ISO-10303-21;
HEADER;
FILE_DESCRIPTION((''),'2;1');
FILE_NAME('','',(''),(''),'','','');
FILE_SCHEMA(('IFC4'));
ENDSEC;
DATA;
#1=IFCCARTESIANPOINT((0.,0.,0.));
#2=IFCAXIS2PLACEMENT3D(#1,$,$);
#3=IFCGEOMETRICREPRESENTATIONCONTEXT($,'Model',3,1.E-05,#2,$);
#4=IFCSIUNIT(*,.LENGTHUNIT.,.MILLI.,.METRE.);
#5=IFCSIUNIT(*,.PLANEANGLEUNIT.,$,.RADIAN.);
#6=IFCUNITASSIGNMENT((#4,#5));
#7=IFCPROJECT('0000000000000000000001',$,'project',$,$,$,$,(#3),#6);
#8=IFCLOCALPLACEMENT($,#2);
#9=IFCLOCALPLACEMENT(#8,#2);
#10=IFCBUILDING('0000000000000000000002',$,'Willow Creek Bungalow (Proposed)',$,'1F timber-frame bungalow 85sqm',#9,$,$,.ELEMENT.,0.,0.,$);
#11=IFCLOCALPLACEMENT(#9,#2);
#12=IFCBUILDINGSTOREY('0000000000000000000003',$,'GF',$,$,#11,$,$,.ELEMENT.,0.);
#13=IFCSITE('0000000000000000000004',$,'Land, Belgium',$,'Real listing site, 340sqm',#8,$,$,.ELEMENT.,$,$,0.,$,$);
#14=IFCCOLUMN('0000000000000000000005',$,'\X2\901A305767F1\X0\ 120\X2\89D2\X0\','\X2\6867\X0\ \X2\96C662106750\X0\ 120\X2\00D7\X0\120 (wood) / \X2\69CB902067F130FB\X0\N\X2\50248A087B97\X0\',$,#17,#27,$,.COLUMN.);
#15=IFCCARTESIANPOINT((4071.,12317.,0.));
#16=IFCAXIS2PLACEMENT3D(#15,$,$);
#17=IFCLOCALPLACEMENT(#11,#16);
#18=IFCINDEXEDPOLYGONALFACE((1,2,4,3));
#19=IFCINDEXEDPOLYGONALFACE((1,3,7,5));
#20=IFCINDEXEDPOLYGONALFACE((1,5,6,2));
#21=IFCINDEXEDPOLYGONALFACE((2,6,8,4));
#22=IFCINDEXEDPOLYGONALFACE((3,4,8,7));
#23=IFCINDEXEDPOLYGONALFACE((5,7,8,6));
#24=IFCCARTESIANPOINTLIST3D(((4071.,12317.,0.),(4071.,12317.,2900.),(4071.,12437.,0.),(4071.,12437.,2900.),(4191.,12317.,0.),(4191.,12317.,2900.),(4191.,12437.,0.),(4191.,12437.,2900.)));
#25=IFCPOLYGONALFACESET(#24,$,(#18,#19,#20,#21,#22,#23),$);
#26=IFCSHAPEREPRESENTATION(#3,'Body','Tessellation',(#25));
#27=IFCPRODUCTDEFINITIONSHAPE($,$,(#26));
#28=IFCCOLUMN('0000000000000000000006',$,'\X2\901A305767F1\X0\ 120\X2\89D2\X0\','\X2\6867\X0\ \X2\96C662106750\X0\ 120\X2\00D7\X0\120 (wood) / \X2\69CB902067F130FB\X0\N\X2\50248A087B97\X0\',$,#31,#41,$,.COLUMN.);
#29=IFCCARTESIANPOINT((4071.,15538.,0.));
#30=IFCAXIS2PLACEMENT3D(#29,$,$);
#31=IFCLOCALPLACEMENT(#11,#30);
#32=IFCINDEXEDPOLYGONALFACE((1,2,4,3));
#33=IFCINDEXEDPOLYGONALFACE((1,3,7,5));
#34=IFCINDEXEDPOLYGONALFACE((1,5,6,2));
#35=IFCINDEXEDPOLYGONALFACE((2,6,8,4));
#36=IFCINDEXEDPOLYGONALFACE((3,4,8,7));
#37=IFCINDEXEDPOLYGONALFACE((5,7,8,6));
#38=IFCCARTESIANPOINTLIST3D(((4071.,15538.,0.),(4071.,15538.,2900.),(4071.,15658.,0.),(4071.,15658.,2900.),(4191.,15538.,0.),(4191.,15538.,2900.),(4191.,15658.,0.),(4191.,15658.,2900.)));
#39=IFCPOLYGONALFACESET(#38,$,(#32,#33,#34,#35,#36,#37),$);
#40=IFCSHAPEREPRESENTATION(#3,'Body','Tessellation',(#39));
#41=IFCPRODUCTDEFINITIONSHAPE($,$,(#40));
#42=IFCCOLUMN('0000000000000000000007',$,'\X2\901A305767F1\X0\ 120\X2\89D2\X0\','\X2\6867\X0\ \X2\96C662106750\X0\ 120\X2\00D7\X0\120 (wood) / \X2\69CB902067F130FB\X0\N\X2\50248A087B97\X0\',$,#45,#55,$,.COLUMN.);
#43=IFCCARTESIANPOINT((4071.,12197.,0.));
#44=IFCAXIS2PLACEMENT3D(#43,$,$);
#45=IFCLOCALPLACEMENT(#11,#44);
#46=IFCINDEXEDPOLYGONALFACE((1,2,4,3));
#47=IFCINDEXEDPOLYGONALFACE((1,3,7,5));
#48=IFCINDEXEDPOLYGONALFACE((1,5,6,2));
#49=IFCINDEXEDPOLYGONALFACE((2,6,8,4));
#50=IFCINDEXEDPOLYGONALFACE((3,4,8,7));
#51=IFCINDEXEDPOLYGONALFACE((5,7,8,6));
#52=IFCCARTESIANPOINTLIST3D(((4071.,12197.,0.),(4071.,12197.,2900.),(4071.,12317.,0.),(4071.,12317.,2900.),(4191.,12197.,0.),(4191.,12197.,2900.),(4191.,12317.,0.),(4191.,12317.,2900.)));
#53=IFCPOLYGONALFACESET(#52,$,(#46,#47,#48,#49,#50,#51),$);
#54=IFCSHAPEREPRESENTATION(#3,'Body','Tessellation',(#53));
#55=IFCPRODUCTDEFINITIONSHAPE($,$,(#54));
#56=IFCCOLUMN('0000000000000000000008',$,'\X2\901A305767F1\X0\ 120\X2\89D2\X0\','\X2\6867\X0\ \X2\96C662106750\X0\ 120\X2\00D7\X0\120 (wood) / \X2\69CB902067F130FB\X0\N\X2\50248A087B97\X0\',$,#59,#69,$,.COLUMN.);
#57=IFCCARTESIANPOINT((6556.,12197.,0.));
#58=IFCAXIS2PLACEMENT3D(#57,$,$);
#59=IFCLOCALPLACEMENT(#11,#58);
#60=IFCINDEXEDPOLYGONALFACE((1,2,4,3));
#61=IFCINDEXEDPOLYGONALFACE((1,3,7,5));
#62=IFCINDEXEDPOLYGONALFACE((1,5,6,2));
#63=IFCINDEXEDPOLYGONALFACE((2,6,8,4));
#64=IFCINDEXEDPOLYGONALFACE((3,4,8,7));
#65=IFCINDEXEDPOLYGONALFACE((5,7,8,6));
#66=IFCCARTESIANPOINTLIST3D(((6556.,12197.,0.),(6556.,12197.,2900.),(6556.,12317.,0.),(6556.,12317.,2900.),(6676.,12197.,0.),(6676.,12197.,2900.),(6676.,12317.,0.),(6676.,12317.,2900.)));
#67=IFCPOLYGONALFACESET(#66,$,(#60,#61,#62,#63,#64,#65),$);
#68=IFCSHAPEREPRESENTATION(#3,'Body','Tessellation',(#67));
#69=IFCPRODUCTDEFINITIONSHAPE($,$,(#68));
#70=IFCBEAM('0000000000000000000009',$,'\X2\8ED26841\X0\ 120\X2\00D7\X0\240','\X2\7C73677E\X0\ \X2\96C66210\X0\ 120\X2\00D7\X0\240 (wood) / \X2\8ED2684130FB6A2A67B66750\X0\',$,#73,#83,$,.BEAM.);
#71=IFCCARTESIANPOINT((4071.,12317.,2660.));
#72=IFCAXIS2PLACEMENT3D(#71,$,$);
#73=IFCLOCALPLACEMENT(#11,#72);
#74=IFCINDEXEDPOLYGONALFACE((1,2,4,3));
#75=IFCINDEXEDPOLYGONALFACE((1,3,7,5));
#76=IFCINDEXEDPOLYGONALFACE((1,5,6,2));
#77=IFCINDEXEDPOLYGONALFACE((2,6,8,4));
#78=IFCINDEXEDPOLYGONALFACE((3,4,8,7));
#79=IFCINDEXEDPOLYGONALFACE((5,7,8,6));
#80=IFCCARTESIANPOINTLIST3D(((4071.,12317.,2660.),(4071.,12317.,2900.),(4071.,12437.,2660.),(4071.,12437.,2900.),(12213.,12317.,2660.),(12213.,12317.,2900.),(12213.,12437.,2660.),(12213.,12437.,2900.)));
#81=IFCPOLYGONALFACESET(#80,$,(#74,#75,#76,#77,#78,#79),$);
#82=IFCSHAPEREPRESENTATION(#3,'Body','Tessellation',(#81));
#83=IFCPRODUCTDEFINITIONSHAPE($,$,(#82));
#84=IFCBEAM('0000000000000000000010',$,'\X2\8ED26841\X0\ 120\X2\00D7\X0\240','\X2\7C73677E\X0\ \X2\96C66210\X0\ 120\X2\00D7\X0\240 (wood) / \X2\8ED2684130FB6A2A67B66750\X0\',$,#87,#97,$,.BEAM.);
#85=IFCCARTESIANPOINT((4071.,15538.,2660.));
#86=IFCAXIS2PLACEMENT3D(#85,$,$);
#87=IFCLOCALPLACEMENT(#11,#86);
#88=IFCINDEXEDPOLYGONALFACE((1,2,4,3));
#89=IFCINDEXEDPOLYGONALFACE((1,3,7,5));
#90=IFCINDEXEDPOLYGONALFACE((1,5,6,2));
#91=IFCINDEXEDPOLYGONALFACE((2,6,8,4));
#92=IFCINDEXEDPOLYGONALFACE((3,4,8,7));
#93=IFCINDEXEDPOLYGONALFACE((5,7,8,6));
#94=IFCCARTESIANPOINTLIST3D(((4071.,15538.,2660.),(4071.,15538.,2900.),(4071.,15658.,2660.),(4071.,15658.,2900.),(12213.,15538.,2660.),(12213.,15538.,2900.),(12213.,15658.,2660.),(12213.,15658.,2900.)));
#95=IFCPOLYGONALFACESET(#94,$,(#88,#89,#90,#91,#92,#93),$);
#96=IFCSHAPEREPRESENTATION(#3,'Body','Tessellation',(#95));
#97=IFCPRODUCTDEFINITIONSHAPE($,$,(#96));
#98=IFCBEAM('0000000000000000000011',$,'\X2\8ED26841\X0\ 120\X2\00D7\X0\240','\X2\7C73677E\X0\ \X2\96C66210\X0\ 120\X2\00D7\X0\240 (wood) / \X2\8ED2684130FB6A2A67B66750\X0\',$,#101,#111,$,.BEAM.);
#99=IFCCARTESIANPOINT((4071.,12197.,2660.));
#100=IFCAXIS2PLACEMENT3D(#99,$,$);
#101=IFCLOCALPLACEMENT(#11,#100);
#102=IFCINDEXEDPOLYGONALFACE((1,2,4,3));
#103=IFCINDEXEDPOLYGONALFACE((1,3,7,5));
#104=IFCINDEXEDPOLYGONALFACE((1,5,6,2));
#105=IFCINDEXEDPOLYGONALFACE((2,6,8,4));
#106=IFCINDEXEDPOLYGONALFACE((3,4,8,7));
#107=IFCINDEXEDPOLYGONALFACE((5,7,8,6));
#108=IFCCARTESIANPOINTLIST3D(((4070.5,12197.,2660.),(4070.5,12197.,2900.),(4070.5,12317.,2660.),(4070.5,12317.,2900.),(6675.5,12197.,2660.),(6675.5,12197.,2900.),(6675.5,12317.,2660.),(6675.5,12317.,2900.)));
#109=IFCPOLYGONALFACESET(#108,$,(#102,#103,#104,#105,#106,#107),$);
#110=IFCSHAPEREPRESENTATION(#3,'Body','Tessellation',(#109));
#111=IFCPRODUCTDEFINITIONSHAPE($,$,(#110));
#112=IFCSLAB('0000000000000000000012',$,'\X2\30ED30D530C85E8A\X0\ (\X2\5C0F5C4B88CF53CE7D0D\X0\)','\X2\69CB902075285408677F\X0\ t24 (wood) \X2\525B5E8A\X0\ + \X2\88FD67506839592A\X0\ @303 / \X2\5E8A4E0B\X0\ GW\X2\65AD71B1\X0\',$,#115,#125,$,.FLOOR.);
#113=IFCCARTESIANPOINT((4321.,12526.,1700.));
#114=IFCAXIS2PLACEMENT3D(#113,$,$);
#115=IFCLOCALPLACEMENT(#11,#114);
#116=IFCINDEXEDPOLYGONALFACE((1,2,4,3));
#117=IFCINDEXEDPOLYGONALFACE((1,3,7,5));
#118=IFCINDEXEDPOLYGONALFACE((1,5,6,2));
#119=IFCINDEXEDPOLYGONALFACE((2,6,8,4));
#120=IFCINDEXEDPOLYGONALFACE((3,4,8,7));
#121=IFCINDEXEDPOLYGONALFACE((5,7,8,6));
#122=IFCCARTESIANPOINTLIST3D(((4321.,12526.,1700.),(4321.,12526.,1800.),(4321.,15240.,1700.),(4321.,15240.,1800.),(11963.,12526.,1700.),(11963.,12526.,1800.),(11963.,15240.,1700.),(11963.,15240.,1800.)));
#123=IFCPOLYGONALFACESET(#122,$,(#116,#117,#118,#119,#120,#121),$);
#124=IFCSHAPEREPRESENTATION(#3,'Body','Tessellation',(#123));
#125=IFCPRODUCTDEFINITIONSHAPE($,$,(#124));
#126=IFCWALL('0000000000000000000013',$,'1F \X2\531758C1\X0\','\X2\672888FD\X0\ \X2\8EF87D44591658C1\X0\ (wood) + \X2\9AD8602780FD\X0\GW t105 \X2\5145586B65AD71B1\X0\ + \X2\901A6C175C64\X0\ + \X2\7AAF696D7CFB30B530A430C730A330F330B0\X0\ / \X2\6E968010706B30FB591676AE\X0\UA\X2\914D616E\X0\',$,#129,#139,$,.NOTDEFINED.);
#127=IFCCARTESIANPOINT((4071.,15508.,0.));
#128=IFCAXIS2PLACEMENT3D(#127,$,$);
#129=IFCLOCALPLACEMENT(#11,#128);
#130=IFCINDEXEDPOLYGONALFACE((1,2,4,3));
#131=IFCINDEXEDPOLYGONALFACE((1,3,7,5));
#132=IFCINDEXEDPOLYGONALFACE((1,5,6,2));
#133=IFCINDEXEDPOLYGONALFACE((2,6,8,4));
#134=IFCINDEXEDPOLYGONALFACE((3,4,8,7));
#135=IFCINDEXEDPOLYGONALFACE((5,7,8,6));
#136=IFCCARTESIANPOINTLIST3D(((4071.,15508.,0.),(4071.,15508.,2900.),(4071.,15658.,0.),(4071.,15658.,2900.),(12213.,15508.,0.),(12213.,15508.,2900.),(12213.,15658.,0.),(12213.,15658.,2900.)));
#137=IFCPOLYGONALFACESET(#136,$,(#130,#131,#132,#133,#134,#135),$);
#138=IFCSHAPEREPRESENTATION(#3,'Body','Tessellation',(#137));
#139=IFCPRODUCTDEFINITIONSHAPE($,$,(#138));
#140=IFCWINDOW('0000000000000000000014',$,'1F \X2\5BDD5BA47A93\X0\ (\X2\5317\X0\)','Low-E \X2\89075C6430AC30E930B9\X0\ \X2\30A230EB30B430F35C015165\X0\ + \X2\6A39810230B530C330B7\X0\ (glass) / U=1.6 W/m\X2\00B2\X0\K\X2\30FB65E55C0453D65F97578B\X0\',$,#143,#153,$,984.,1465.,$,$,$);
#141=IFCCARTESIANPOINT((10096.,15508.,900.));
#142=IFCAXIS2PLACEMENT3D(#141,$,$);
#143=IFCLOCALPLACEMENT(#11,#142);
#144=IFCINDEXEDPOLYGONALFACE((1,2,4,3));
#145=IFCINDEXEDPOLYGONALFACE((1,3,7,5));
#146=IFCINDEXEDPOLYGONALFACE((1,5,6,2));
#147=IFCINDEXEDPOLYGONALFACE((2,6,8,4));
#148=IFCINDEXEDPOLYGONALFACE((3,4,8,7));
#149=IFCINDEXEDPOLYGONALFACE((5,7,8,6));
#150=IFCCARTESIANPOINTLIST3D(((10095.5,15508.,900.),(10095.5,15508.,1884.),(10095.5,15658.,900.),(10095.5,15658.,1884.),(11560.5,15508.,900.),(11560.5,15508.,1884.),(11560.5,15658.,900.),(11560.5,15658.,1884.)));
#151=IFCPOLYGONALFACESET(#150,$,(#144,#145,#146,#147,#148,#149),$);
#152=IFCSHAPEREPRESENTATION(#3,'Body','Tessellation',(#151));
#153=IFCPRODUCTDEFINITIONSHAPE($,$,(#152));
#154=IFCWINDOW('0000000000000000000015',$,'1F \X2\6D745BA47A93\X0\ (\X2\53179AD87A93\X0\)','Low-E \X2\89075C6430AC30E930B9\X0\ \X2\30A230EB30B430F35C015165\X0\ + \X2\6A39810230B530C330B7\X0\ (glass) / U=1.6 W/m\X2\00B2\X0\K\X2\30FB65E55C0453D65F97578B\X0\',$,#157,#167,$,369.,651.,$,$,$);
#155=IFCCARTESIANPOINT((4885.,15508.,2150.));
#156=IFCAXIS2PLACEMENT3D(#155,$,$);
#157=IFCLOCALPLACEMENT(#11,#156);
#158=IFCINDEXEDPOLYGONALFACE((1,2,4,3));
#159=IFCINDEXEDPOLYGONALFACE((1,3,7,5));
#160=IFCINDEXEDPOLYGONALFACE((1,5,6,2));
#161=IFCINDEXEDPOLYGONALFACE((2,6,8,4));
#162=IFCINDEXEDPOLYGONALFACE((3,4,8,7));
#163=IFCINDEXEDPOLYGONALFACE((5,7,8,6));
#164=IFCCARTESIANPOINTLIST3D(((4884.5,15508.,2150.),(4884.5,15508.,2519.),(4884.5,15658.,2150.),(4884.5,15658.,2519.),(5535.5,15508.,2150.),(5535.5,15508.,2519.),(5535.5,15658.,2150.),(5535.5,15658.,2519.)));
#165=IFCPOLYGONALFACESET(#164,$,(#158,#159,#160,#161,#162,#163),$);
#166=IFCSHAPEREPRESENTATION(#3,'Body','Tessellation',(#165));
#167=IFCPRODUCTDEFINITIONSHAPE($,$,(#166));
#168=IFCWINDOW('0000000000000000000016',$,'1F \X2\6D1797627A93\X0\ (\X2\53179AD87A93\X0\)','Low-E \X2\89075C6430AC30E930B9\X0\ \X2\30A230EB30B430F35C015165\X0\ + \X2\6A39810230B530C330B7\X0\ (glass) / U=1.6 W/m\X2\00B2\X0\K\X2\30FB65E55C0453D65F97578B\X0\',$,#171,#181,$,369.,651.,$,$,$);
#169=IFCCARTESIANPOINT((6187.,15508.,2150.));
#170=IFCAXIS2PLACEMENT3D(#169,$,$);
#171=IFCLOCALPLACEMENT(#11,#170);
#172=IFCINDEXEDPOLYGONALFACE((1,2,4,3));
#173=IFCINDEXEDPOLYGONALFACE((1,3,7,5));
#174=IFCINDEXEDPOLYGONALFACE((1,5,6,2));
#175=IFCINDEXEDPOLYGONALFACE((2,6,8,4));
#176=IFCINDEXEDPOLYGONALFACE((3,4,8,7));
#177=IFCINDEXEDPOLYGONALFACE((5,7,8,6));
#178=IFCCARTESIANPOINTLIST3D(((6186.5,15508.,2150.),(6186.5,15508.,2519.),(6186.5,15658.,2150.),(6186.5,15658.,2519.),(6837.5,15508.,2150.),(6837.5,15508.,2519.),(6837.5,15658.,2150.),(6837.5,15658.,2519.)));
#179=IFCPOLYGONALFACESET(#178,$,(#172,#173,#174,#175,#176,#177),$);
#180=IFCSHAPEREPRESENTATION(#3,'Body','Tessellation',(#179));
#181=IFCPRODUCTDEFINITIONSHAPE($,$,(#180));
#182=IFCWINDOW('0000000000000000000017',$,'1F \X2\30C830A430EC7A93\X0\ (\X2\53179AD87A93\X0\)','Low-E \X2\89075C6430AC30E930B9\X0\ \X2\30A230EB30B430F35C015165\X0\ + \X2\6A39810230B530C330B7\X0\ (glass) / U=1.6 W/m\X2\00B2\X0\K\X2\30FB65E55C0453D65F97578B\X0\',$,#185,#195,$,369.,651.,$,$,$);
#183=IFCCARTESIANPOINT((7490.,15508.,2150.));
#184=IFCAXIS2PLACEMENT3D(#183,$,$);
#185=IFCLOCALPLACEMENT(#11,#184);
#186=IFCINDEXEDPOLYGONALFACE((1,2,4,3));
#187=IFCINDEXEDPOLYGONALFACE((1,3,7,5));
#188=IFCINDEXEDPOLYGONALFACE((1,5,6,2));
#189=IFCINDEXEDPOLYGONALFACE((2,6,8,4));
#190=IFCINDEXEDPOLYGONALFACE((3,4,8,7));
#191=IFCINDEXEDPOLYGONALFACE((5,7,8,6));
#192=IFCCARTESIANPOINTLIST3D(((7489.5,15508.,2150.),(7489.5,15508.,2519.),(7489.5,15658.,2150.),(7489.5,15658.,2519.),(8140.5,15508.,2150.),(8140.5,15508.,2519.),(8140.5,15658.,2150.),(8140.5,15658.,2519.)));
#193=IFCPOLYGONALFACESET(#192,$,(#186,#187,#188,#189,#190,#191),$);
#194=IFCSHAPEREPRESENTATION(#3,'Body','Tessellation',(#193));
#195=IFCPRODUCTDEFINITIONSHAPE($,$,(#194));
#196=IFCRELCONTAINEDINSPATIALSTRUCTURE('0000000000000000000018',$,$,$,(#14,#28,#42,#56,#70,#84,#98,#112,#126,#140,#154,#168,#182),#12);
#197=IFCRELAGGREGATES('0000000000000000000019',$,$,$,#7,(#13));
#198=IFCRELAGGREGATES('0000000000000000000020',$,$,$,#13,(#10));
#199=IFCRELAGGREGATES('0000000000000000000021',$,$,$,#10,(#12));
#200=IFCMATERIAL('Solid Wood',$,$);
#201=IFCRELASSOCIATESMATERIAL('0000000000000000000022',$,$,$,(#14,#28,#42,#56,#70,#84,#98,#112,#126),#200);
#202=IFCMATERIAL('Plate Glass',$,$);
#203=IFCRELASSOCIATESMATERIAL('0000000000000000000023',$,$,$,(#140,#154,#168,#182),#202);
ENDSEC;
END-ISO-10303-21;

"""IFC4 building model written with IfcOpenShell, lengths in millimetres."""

from ifc_helpers import new_model, si_unit, frame, frame_2d, origin, place, context, project, spatial, rectangle, extrude, material, element, fill, save


model = new_model("IFC4")

# Units and contexts
model_context = context("Model", 3, precision=1e-05, world=origin())
ifc_project = project(units=[si_unit("LENGTHUNIT", "METRE", prefix="MILLI"), si_unit("PLANEANGLEUNIT", "RADIAN")], contexts=[model_context])

# Site, building, storey
site_placement = place(None, origin())
site = spatial("IfcSite", under=ifc_project, at=site_placement, Name="Land, Belgium", ObjectType="Real listing site, 340sqm", CompositionType="ELEMENT", RefElevation=0.0)
building_placement = place(site_placement, origin())
building = spatial("IfcBuilding", under=site, at=building_placement, Name="Willow Creek Bungalow (Proposed)", ObjectType="1F timber-frame bungalow 85sqm", CompositionType="ELEMENT", ElevationOfRefHeight=0.0, ElevationOfTerrain=0.0)
storey_placement = place(building_placement, origin())
storey = spatial("IfcBuildingStorey", under=building, at=storey_placement, Name="GF", CompositionType="ELEMENT", Elevation=0.0)

# Columns
ifc_material_1 = material(Name="Solid Wood")
column_1_placement = place(storey_placement, frame((4071.0, 12317.0, 0.0)))
element("IfcColumn", 1, at=column_1_placement, inside=storey, material=ifc_material_1, Name="通し柱 120角", Description="桧 集成材 120×120 (wood) / 構造柱・N値計算", PredefinedType="COLUMN", context=model_context, shape_type="SweptSolid", body=[
    extrude(rectangle(XDim=120.0, YDim=120.0, at=frame_2d((60.0, 60.0))), frame((4071.0, 12317.0, 0.0)), (0.0, 0.0, 1.0), 2900.0),
])
column_2_placement = place(storey_placement, frame((4071.0, 15538.0, 0.0)))
element("IfcColumn", 2, at=column_2_placement, inside=storey, material=ifc_material_1, Name="通し柱 120角", Description="桧 集成材 120×120 (wood) / 構造柱・N値計算", PredefinedType="COLUMN", context=model_context, shape_type="SweptSolid", body=[
    extrude(rectangle(XDim=120.0, YDim=120.0, at=frame_2d((60.0, 60.0))), frame((4071.0, 15538.0, 0.0)), (0.0, 0.0, 1.0), 2900.0),
])
column_3_placement = place(storey_placement, frame((4071.0, 12197.0, 0.0)))
element("IfcColumn", 3, at=column_3_placement, inside=storey, material=ifc_material_1, Name="通し柱 120角", Description="桧 集成材 120×120 (wood) / 構造柱・N値計算", PredefinedType="COLUMN", context=model_context, shape_type="SweptSolid", body=[
    extrude(rectangle(XDim=120.0, YDim=120.0, at=frame_2d((60.0, 60.0))), frame((4071.0, 12197.0, 0.0)), (0.0, 0.0, 1.0), 2900.0),
])
column_4_placement = place(storey_placement, frame((6556.0, 12197.0, 0.0)))
element("IfcColumn", 4, at=column_4_placement, inside=storey, material=ifc_material_1, Name="通し柱 120角", Description="桧 集成材 120×120 (wood) / 構造柱・N値計算", PredefinedType="COLUMN", context=model_context, shape_type="SweptSolid", body=[
    extrude(rectangle(XDim=120.0, YDim=120.0, at=frame_2d((60.0, 60.0))), frame((6556.0, 12197.0, 0.0)), (0.0, 0.0, 1.0), 2900.0),
])

# Beams
beam_1_placement = place(storey_placement, frame((4071.0, 12317.0, 2660.0)))
element("IfcBeam", 5, at=beam_1_placement, inside=storey, material=ifc_material_1, Name="軒桁 120×240", Description="米松 集成 120×240 (wood) / 軒桁・横架材", PredefinedType="BEAM", context=model_context, shape_type="SweptSolid", body=[
    extrude(rectangle(XDim=8142.0, YDim=120.0, at=frame_2d((4071.0, 60.0))), frame((4071.0, 12317.0, 2660.0)), (0.0, 0.0, 1.0), 240.0),
])
beam_2_placement = place(storey_placement, frame((4071.0, 15538.0, 2660.0)))
element("IfcBeam", 6, at=beam_2_placement, inside=storey, material=ifc_material_1, Name="軒桁 120×240", Description="米松 集成 120×240 (wood) / 軒桁・横架材", PredefinedType="BEAM", context=model_context, shape_type="SweptSolid", body=[
    extrude(rectangle(XDim=8142.0, YDim=120.0, at=frame_2d((4071.0, 60.0))), frame((4071.0, 15538.0, 2660.0)), (0.0, 0.0, 1.0), 240.0),
])
beam_3_placement = place(storey_placement, frame((4071.0, 12197.0, 2660.0)))
element("IfcBeam", 7, at=beam_3_placement, inside=storey, material=ifc_material_1, Name="軒桁 120×240", Description="米松 集成 120×240 (wood) / 軒桁・横架材", PredefinedType="BEAM", context=model_context, shape_type="SweptSolid", body=[
    extrude(rectangle(XDim=2605.0, YDim=120.0, at=frame_2d((1302.0, 60.0))), frame((4071.0, 12197.0, 2660.0)), (0.0, 0.0, 1.0), 240.0),
])

# Slab
slab_1_placement = place(storey_placement, frame((4321.0, 12526.0, 1700.0)))
element("IfcSlab", 8, at=slab_1_placement, inside=storey, material=ifc_material_1, Name="ロフト床 (小屋裏収納)", Description="構造用合板 t24 (wood) 剛床 + 製材根太 @303 / 床下 GW断熱", PredefinedType="FLOOR", context=model_context, shape_type="SweptSolid", body=[
    extrude(rectangle(XDim=7642.0, YDim=2714.0, at=frame_2d((3821.0, 1357.0))), frame((4321.0, 12526.0, 1700.0)), (0.0, 0.0, 1.0), 100.0),
])

# Wall, openings, windows
wall_1_placement = place(storey_placement, frame((4071.0, 15508.0, 0.0)))
wall_1 = element("IfcWall", 9, at=wall_1_placement, inside=storey, material=ifc_material_1, Name="1F 北壁", Description="木製 軸組外壁 (wood) + 高性能GW t105 充填断熱 + 通気層 + 窯業系サイディング / 準耐火・外皮UA配慮", PredefinedType="NOTDEFINED", context=model_context, shape_type="SweptSolid", body=[
    extrude(rectangle(XDim=8142.0, YDim=150.0, at=frame_2d((4071.0, 75.0))), frame((4071.0, 15508.0, 0.0)), (0.0, 0.0, 1.0), 2900.0),
])
opening_1_placement = place(storey_placement, frame((10096.0, 15508.0, 900.0)))
opening_1 = element("IfcOpeningElement", 10, at=opening_1_placement, cuts=wall_1, PredefinedType="NOTDEFINED", context=model_context, shape_type="SweptSolid", body=[
    extrude(rectangle(XDim=1465.0, YDim=150.0, at=frame_2d((732.0, 75.0))), frame((10096.0, 15508.0, 900.0)), (0.0, 0.0, 1.0), 984.0),
])
opening_2_placement = place(storey_placement, frame((4885.0, 15508.0, 2150.0)))
opening_2 = element("IfcOpeningElement", 11, at=opening_2_placement, cuts=wall_1, PredefinedType="NOTDEFINED", context=model_context, shape_type="SweptSolid", body=[
    extrude(rectangle(XDim=651.0, YDim=150.0, at=frame_2d((325.0, 75.0))), frame((4885.0, 15508.0, 2150.0)), (0.0, 0.0, 1.0), 369.0),
])
opening_3_placement = place(storey_placement, frame((6187.0, 15508.0, 2150.0)))
opening_3 = element("IfcOpeningElement", 12, at=opening_3_placement, cuts=wall_1, PredefinedType="NOTDEFINED", context=model_context, shape_type="SweptSolid", body=[
    extrude(rectangle(XDim=651.0, YDim=150.0, at=frame_2d((325.0, 75.0))), frame((6187.0, 15508.0, 2150.0)), (0.0, 0.0, 1.0), 369.0),
])
opening_4_placement = place(storey_placement, frame((7490.0, 15508.0, 2150.0)))
opening_4 = element("IfcOpeningElement", 13, at=opening_4_placement, cuts=wall_1, PredefinedType="NOTDEFINED", context=model_context, shape_type="SweptSolid", body=[
    extrude(rectangle(XDim=651.0, YDim=150.0, at=frame_2d((325.0, 75.0))), frame((7490.0, 15508.0, 2150.0)), (0.0, 0.0, 1.0), 369.0),
])
ifc_material_2 = material(Name="Plate Glass")
window_1_placement = place(storey_placement, frame((10096.0, 15508.0, 900.0)))
window_1 = element("IfcWindow", 14, at=window_1_placement, inside=storey, material=ifc_material_2, Name="1F 寝室窓 (北)", Description="Low-E 複層ガラス アルゴン封入 + 樹脂サッシ (glass) / U=1.6 W/m²K・日射取得型", OverallHeight=984.0, OverallWidth=1465.0, context=model_context, shape_type="SweptSolid", body=[
    extrude(rectangle(XDim=1465.0, YDim=150.0, at=frame_2d((732.0, 75.0))), frame((10096.0, 15508.0, 900.0)), (0.0, 0.0, 1.0), 984.0),
])
fill(opening_1, window_1)
window_2_placement = place(storey_placement, frame((4885.0, 15508.0, 2150.0)))
window_2 = element("IfcWindow", 15, at=window_2_placement, inside=storey, material=ifc_material_2, Name="1F 浴室窓 (北高窓)", Description="Low-E 複層ガラス アルゴン封入 + 樹脂サッシ (glass) / U=1.6 W/m²K・日射取得型", OverallHeight=369.0, OverallWidth=651.0, context=model_context, shape_type="SweptSolid", body=[
    extrude(rectangle(XDim=651.0, YDim=150.0, at=frame_2d((325.0, 75.0))), frame((4885.0, 15508.0, 2150.0)), (0.0, 0.0, 1.0), 369.0),
])
fill(opening_2, window_2)
window_3_placement = place(storey_placement, frame((6187.0, 15508.0, 2150.0)))
window_3 = element("IfcWindow", 16, at=window_3_placement, inside=storey, material=ifc_material_2, Name="1F 洗面窓 (北高窓)", Description="Low-E 複層ガラス アルゴン封入 + 樹脂サッシ (glass) / U=1.6 W/m²K・日射取得型", OverallHeight=369.0, OverallWidth=651.0, context=model_context, shape_type="SweptSolid", body=[
    extrude(rectangle(XDim=651.0, YDim=150.0, at=frame_2d((325.0, 75.0))), frame((6187.0, 15508.0, 2150.0)), (0.0, 0.0, 1.0), 369.0),
])
fill(opening_3, window_3)
window_4_placement = place(storey_placement, frame((7490.0, 15508.0, 2150.0)))
window_4 = element("IfcWindow", 17, at=window_4_placement, inside=storey, material=ifc_material_2, Name="1F トイレ窓 (北高窓)", Description="Low-E 複層ガラス アルゴン封入 + 樹脂サッシ (glass) / U=1.6 W/m²K・日射取得型", OverallHeight=369.0, OverallWidth=651.0, context=model_context, shape_type="SweptSolid", body=[
    extrude(rectangle(XDim=651.0, YDim=150.0, at=frame_2d((325.0, 75.0))), frame((7490.0, 15508.0, 2150.0)), (0.0, 0.0, 1.0), 369.0),
])
fill(opening_4, window_4)

save(model, "model.ifc")
